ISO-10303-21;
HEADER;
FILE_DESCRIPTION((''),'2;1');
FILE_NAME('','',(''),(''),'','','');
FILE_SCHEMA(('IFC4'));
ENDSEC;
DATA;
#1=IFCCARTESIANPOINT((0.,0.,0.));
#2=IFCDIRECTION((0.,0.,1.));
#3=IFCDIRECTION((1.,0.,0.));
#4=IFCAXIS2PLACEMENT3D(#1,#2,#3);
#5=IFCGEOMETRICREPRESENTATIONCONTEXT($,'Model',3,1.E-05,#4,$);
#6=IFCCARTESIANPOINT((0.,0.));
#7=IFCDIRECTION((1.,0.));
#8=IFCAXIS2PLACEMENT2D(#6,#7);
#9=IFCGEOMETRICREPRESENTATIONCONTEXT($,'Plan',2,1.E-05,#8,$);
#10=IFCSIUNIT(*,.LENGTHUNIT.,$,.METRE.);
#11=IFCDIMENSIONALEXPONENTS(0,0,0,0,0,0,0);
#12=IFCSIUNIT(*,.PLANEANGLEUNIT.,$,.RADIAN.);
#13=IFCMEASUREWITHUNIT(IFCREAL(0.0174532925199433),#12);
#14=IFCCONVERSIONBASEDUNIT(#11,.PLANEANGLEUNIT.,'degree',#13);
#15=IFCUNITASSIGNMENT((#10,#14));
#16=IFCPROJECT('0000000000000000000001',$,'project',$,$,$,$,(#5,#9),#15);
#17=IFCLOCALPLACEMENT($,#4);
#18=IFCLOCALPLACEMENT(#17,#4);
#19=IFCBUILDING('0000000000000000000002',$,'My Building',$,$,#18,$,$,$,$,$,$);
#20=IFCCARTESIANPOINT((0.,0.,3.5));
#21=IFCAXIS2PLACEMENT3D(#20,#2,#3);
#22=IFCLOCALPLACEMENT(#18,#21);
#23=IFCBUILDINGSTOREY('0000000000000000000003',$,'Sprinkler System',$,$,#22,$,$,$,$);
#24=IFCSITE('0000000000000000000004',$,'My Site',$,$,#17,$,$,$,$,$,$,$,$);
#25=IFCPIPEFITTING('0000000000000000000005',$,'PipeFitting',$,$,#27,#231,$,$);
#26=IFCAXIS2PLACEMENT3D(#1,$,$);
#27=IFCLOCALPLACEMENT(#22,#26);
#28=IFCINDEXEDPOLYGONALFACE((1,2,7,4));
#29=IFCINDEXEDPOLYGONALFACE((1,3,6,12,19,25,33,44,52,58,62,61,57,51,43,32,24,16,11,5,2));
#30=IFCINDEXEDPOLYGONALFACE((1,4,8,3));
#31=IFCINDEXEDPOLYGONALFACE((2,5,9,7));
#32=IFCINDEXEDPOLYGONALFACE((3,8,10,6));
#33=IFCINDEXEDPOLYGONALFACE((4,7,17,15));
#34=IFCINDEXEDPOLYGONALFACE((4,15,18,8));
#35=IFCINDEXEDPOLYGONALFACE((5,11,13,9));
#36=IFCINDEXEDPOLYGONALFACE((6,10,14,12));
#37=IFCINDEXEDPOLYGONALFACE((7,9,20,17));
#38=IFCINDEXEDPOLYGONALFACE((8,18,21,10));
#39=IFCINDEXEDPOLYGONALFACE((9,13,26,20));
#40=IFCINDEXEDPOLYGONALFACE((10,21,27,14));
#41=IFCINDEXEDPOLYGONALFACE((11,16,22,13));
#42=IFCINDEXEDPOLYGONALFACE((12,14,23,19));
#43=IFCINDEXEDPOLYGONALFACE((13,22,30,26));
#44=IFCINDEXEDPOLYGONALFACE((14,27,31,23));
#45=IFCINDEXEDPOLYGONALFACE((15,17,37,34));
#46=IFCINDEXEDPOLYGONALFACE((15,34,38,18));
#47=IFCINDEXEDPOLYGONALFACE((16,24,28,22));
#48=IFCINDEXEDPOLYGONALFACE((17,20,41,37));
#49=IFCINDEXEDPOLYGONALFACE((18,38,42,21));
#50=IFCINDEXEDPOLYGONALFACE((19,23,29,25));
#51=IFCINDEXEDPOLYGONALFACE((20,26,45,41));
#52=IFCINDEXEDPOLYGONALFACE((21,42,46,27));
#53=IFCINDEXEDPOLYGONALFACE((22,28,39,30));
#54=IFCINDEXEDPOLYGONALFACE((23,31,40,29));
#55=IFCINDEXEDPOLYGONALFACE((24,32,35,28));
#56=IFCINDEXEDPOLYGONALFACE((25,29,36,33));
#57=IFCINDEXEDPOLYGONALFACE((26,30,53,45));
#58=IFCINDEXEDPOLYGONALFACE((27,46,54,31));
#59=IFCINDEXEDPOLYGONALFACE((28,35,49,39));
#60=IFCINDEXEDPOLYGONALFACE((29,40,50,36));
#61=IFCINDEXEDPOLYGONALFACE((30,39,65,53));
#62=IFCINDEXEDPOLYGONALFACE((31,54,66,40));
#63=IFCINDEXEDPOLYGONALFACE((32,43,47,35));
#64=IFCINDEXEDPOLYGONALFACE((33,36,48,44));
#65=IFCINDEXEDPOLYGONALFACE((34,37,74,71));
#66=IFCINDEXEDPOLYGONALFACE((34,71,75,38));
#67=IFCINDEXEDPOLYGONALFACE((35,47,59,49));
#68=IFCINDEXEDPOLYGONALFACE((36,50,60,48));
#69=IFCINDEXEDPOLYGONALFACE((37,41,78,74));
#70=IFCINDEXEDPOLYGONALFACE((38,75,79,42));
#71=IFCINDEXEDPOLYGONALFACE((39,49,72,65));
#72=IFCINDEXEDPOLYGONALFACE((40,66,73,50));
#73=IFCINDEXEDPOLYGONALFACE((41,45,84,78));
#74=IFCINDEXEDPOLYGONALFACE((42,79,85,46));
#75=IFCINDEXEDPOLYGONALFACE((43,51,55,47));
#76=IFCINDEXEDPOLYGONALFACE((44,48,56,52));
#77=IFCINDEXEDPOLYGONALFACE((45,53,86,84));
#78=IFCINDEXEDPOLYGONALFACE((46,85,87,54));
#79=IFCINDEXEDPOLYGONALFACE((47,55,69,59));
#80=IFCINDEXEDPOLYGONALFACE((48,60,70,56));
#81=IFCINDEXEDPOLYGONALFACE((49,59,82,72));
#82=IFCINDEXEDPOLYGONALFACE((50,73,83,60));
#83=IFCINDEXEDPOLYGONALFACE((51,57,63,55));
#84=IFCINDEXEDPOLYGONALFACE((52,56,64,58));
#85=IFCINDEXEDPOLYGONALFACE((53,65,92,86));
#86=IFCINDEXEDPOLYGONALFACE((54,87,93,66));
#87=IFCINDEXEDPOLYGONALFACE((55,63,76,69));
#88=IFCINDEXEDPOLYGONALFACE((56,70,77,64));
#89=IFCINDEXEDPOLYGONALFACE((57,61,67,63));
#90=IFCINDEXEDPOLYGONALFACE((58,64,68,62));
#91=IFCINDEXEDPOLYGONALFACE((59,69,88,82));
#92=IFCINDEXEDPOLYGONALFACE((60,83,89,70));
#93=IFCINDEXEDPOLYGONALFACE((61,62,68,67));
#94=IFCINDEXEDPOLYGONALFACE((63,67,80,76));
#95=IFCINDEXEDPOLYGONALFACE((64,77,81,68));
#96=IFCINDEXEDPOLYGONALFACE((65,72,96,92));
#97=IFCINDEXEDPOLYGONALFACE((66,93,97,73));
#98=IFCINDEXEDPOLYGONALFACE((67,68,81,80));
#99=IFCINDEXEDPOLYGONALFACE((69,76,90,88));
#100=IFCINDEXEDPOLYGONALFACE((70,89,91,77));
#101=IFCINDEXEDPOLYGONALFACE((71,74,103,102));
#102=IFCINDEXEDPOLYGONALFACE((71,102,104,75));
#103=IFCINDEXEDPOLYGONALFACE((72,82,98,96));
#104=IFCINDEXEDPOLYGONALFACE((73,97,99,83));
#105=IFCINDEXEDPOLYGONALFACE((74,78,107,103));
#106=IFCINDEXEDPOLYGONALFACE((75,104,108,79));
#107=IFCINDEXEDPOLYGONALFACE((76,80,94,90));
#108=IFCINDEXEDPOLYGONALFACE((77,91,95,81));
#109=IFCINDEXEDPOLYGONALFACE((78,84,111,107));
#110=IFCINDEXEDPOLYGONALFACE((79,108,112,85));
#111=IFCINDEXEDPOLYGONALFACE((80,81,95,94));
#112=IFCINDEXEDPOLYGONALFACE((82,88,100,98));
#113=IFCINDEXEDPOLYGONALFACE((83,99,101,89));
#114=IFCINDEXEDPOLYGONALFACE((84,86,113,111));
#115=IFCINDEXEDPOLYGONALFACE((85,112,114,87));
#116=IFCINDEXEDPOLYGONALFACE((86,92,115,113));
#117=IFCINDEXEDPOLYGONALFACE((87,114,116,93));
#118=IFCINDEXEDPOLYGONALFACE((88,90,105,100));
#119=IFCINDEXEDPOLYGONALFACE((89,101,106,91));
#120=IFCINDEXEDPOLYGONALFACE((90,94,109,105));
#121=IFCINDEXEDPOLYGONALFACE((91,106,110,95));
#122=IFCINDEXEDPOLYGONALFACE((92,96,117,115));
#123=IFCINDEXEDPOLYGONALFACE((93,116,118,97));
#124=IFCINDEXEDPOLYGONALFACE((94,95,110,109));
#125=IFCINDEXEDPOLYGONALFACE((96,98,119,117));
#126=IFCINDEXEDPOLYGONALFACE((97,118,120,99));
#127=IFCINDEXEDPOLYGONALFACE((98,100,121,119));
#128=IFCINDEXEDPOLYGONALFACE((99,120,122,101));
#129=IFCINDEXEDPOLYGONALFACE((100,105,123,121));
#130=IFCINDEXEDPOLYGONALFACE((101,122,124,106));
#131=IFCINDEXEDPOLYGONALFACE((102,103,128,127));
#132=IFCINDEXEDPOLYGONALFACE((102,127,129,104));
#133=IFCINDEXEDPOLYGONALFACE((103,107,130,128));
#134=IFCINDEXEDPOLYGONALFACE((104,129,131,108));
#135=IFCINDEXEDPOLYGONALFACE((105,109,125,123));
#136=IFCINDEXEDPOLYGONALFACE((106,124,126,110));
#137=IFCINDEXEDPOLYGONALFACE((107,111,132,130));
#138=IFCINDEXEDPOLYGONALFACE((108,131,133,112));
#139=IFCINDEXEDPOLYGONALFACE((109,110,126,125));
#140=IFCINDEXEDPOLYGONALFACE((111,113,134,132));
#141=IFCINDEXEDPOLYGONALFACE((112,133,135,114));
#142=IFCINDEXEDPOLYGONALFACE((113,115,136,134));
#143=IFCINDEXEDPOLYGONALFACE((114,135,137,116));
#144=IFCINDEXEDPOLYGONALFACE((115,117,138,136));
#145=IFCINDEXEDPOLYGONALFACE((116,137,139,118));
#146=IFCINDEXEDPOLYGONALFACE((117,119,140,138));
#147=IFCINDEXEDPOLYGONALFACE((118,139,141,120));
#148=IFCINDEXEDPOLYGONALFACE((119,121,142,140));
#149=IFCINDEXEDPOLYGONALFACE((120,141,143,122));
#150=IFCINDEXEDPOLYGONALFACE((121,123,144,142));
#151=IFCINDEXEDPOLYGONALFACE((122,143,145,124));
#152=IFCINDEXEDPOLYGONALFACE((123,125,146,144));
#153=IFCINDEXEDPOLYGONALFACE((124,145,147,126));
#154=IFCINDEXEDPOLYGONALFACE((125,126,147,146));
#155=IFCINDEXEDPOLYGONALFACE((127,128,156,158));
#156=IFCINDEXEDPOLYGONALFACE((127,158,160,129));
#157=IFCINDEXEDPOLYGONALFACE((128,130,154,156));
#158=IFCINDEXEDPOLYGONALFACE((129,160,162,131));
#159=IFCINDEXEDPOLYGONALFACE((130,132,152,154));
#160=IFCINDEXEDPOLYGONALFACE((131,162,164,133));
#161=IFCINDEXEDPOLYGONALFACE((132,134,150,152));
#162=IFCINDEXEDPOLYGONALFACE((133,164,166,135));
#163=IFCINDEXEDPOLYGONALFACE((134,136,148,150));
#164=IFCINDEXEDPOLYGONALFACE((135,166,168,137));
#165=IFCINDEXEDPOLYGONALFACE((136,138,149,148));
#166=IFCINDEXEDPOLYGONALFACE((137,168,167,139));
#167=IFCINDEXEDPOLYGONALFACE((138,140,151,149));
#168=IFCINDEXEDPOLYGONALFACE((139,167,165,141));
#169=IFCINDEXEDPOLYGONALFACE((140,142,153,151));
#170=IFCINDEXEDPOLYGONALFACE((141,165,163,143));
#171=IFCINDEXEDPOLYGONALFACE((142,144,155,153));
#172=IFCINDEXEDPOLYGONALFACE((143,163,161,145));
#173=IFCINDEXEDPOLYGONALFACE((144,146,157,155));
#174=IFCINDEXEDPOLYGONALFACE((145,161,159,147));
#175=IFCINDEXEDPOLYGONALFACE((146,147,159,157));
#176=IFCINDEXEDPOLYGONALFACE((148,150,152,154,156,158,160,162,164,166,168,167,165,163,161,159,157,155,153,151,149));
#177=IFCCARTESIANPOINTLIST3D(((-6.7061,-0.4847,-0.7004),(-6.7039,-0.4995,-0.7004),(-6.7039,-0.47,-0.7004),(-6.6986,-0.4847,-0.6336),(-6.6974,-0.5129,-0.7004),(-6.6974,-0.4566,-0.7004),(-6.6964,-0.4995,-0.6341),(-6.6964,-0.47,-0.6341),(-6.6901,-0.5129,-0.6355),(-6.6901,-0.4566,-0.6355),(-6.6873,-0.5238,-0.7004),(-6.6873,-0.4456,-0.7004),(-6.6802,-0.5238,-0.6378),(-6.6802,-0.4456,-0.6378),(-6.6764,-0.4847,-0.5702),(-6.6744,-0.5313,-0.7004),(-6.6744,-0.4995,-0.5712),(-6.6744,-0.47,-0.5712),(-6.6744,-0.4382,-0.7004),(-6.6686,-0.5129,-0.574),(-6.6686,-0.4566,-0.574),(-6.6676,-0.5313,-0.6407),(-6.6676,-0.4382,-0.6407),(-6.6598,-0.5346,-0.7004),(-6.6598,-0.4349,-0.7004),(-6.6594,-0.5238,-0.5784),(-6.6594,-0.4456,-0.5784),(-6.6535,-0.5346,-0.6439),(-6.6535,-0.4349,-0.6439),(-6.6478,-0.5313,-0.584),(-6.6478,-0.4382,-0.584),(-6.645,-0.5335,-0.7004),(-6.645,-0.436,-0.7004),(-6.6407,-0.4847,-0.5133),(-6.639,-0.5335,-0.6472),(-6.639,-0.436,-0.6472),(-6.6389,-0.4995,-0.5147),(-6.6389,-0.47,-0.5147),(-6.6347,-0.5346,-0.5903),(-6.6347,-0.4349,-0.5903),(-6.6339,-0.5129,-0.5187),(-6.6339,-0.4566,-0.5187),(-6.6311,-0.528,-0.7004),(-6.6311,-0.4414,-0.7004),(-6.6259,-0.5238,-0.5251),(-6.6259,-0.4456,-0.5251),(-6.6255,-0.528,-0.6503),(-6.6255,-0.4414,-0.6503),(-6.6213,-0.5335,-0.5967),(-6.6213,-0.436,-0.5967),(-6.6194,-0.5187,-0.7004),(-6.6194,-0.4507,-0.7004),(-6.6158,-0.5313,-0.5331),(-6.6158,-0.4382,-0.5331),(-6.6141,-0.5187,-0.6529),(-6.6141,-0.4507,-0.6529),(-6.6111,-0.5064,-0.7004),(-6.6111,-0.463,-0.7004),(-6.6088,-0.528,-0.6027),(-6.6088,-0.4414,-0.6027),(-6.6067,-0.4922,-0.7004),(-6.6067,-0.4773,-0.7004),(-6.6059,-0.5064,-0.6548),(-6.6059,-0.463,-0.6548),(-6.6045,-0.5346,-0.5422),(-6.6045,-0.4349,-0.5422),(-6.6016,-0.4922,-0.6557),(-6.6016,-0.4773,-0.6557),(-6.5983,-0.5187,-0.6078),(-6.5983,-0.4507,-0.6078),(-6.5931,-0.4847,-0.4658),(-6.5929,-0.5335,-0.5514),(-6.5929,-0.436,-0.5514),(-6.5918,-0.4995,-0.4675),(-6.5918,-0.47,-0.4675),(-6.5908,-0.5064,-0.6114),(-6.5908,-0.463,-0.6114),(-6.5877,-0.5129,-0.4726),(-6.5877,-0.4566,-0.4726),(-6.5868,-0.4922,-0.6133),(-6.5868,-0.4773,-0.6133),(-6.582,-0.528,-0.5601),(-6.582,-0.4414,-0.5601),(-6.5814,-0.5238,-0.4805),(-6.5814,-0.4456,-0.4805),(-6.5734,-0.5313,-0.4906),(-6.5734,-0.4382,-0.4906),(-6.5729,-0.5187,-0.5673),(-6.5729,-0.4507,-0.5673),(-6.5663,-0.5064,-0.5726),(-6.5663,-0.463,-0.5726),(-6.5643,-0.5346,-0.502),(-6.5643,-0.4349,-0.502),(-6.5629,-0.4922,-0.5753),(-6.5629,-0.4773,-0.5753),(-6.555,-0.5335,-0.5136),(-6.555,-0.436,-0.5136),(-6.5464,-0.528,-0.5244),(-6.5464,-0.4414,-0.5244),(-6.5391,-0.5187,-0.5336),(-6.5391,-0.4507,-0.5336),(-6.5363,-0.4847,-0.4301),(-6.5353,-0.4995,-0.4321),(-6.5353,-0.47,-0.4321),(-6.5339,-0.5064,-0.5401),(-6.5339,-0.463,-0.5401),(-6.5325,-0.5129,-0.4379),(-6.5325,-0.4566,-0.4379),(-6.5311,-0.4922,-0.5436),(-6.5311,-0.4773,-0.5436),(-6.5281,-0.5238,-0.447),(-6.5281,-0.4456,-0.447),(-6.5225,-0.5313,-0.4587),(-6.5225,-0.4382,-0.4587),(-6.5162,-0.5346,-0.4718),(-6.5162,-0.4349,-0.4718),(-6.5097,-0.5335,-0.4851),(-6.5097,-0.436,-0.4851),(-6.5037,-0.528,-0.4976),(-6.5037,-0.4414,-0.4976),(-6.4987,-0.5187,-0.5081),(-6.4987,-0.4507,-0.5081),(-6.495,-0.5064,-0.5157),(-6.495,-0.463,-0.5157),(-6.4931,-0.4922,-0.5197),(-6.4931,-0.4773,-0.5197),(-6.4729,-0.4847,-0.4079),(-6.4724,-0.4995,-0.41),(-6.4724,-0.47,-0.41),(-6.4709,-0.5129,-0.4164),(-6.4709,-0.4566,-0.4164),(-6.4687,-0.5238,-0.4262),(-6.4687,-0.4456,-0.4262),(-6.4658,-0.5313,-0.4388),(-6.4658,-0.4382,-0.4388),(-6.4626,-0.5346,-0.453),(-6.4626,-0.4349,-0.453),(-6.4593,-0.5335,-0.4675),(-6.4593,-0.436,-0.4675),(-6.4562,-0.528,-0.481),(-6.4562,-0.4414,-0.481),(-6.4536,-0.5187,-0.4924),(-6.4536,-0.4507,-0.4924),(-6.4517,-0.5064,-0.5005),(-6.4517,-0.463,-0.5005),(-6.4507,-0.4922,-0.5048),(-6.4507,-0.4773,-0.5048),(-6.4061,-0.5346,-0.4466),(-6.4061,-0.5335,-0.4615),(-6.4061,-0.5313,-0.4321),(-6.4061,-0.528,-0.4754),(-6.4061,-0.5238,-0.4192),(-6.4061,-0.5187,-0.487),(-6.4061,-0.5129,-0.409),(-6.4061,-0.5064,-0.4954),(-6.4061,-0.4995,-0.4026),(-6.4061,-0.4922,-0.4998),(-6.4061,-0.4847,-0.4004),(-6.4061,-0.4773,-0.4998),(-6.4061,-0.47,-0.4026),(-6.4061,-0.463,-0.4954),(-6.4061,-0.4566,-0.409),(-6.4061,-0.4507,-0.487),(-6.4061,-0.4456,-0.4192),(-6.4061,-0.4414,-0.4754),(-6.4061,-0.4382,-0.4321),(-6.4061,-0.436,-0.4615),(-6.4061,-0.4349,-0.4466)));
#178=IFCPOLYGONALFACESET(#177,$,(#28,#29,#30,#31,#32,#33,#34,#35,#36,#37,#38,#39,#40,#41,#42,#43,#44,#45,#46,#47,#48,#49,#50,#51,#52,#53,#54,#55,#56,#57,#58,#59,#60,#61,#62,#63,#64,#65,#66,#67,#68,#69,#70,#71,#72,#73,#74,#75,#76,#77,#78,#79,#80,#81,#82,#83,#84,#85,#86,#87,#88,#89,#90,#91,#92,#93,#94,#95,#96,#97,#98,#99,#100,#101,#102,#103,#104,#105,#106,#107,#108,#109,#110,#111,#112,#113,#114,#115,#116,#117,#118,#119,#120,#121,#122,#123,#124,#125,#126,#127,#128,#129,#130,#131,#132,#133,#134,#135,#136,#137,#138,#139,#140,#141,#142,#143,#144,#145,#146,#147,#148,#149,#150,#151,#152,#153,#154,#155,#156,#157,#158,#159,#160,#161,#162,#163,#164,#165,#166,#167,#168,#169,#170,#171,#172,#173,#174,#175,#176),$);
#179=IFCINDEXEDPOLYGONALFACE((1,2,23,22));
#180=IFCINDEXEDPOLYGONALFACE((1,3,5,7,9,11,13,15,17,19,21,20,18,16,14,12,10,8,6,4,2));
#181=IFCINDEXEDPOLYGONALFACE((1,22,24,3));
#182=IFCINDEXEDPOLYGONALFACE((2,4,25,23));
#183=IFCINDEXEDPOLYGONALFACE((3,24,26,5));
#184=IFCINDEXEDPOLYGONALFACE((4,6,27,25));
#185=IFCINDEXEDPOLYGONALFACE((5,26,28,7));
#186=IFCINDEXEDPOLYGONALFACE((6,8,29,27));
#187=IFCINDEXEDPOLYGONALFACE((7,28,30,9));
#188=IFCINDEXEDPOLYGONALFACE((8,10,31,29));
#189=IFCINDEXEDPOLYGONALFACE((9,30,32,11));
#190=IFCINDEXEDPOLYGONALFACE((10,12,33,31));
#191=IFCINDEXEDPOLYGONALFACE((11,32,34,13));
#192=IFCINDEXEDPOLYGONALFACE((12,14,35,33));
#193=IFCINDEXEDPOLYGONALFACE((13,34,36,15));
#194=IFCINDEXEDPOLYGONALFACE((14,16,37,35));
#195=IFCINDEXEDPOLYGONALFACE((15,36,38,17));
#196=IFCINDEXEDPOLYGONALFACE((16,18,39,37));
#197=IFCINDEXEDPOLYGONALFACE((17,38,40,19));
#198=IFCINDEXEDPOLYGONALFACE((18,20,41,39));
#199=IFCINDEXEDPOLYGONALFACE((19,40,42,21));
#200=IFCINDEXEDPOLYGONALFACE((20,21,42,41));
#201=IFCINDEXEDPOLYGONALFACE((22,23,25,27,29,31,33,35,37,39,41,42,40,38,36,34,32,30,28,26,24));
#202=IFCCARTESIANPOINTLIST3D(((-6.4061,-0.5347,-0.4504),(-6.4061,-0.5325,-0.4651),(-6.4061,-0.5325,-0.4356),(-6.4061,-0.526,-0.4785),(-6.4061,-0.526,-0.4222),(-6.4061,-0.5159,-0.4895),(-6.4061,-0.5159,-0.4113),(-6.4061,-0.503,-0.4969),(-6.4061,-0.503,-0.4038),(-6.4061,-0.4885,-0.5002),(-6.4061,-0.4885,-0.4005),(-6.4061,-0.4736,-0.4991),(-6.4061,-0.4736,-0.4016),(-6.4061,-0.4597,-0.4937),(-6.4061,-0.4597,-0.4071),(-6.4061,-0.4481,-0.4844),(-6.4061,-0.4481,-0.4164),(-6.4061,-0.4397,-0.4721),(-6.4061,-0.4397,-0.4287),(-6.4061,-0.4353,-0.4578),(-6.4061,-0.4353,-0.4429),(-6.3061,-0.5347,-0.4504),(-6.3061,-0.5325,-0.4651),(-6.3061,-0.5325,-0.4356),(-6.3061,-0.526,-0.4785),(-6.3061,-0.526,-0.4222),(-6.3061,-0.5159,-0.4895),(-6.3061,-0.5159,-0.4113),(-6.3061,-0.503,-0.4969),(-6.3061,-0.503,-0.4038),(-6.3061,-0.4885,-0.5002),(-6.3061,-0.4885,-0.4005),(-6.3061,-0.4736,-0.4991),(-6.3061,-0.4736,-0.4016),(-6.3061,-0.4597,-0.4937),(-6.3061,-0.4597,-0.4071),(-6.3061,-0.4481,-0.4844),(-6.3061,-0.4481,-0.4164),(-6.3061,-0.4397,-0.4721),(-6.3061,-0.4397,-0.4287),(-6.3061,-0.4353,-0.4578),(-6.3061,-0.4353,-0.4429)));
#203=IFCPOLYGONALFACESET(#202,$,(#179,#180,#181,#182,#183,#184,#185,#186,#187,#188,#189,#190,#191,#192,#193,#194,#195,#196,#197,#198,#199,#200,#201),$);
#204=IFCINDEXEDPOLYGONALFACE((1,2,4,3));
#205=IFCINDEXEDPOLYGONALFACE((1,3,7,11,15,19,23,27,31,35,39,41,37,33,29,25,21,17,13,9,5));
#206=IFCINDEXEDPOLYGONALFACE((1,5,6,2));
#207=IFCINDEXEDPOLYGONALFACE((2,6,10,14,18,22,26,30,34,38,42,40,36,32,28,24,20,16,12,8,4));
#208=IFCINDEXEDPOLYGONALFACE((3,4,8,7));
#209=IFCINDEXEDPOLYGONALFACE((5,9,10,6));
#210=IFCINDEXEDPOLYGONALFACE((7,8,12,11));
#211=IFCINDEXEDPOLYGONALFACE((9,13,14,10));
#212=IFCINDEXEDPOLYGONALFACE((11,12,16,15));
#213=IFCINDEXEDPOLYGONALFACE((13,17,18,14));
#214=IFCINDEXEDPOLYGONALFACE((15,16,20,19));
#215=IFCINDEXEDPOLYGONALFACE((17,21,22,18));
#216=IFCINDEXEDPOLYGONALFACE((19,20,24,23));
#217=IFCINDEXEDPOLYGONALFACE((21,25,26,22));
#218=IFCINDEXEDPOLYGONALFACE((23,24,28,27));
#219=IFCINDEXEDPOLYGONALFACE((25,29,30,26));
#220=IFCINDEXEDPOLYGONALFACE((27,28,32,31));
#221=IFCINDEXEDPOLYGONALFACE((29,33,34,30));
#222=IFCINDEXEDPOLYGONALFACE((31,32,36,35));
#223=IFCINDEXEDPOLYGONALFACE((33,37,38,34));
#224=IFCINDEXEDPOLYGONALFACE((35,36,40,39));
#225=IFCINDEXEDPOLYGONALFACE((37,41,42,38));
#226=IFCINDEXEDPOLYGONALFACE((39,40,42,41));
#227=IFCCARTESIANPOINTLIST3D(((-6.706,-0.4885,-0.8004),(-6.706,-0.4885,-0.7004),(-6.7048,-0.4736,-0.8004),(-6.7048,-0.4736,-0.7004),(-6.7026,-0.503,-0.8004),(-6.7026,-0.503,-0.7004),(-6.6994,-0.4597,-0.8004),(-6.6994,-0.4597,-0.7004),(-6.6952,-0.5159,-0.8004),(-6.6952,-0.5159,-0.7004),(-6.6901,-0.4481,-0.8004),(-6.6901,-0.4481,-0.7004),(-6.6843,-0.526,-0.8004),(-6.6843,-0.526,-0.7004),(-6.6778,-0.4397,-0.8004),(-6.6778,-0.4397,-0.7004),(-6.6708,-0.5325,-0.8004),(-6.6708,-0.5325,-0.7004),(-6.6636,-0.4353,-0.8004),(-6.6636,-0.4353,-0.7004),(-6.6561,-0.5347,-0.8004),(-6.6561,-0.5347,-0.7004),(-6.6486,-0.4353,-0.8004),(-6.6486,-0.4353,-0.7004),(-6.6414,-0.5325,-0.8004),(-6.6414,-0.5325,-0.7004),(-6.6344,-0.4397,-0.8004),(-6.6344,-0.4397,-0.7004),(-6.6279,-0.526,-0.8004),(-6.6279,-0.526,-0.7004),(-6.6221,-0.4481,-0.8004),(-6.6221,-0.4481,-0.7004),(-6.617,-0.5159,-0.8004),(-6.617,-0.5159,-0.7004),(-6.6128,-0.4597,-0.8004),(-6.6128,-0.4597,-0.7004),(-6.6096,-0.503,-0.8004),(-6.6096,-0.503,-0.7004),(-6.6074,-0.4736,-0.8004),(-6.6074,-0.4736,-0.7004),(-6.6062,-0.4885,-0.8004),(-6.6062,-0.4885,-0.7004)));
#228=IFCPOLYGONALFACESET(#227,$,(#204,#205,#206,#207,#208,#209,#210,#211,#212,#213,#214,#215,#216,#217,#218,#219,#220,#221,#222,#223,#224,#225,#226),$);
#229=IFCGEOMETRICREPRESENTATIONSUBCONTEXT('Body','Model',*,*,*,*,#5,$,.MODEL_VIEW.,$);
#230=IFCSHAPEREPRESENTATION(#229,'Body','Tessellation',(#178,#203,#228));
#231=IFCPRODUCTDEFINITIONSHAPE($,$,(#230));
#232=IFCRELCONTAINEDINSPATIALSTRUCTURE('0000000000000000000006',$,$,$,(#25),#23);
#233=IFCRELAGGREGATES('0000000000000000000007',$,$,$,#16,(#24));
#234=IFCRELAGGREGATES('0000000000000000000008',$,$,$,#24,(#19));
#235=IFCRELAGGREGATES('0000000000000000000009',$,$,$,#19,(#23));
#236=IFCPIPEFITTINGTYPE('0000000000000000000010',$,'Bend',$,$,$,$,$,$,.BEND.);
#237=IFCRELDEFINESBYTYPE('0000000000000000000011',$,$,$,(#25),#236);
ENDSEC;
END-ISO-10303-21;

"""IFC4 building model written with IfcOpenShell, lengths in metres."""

from ifc_helpers import new_model, entity, si_unit, converted_unit, frame, origin_with_axes, origin_2d_with_axis, place, context, subcontext, project, spatial, circle, extrude, source, transform, mapped, type_object, type_shapes, element, save


model = new_model("IFC4")

# Units and contexts
model_context = context("Model", 3, precision=1e-05, world=origin_with_axes())
plan_context = context("Plan", 2, precision=1e-05, world=origin_2d_with_axis())
body_context = subcontext(model_context, "Body", "Model", "MODEL_VIEW")
ifc_project = project(units=[si_unit("LENGTHUNIT", "METRE"), converted_unit("PLANEANGLEUNIT", "degree", entity("IfcReal", 0.0174532925199433), si_unit("PLANEANGLEUNIT", "RADIAN"), dimensions=[0, 0, 0, 0, 0, 0, 0])], contexts=[model_context, plan_context])

# Site, building, storey
site_placement = place(None, origin_with_axes())
site = spatial("IfcSite", under=ifc_project, at=site_placement, Name="My Site")
building_placement = place(site_placement, origin_with_axes())
building = spatial("IfcBuilding", under=site, at=building_placement, Name="My Building")
storey_placement = place(building_placement, frame((0.0, 0.0, 3.5), z_axis=(0.0, 0.0, 1.0), x_axis=(1.0, 0.0, 0.0)))
storey = spatial("IfcBuildingStorey", under=building, at=storey_placement, Name="Sprinkler System")

# Pipe fitting
pipe_fitting_type_1 = type_object("IfcPipeFittingType", Name="Bend", PredefinedType="BEND")
shared_shape_1 = source(origin_with_axes(), body_context, "Body", "SolidModel", [
    entity("IfcSweptDiskSolid", entity("IfcIndexedPolyCurve", entity("IfcCartesianPointList3D", [[0.0, 0.0, 0.1], [0.0, -0.0732, 0.2768], [0.0, -0.25, 0.35]]), [entity("IfcArcIndex", [1, 2, 3])]), 0.05),
    extrude(circle(Radius=0.05), origin_with_axes(), (0.0, 0.0, 1.0), 0.1),
    extrude(circle(Radius=0.05), frame((0.0, -0.25, 0.35), z_axis=(0.0, -1.0, 0.0), x_axis=(1.0, 0.0, 0.0)), (0.0, 0.0, 1.0), 0.1),
])
type_shapes(pipe_fitting_type_1, [shared_shape_1])
for number, where, z_axis, x_axis, name in (
    (1, (-6.3061, -0.4847, -0.4504), (-1.0, 0.0, 0.0), (0.0, -1.0, 0.0), "PipeFitting"),
):
    element("IfcPipeFitting", number, at=place(storey_placement, frame(where, z_axis=z_axis, x_axis=x_axis)), inside=storey, type_object=pipe_fitting_type_1, Name=name, context=body_context, shape_type="MappedRepresentation", body=[
        mapped(shared_shape_1, transform((0.0, 0.0, 0.0), x_axis=(1.0, 0.0, 0.0), y_axis=(0.0, 1.0, 0.0), z_axis=(0.0, 0.0, 1.0), scale=1.0)),
    ])

save(model, "model.ifc")
